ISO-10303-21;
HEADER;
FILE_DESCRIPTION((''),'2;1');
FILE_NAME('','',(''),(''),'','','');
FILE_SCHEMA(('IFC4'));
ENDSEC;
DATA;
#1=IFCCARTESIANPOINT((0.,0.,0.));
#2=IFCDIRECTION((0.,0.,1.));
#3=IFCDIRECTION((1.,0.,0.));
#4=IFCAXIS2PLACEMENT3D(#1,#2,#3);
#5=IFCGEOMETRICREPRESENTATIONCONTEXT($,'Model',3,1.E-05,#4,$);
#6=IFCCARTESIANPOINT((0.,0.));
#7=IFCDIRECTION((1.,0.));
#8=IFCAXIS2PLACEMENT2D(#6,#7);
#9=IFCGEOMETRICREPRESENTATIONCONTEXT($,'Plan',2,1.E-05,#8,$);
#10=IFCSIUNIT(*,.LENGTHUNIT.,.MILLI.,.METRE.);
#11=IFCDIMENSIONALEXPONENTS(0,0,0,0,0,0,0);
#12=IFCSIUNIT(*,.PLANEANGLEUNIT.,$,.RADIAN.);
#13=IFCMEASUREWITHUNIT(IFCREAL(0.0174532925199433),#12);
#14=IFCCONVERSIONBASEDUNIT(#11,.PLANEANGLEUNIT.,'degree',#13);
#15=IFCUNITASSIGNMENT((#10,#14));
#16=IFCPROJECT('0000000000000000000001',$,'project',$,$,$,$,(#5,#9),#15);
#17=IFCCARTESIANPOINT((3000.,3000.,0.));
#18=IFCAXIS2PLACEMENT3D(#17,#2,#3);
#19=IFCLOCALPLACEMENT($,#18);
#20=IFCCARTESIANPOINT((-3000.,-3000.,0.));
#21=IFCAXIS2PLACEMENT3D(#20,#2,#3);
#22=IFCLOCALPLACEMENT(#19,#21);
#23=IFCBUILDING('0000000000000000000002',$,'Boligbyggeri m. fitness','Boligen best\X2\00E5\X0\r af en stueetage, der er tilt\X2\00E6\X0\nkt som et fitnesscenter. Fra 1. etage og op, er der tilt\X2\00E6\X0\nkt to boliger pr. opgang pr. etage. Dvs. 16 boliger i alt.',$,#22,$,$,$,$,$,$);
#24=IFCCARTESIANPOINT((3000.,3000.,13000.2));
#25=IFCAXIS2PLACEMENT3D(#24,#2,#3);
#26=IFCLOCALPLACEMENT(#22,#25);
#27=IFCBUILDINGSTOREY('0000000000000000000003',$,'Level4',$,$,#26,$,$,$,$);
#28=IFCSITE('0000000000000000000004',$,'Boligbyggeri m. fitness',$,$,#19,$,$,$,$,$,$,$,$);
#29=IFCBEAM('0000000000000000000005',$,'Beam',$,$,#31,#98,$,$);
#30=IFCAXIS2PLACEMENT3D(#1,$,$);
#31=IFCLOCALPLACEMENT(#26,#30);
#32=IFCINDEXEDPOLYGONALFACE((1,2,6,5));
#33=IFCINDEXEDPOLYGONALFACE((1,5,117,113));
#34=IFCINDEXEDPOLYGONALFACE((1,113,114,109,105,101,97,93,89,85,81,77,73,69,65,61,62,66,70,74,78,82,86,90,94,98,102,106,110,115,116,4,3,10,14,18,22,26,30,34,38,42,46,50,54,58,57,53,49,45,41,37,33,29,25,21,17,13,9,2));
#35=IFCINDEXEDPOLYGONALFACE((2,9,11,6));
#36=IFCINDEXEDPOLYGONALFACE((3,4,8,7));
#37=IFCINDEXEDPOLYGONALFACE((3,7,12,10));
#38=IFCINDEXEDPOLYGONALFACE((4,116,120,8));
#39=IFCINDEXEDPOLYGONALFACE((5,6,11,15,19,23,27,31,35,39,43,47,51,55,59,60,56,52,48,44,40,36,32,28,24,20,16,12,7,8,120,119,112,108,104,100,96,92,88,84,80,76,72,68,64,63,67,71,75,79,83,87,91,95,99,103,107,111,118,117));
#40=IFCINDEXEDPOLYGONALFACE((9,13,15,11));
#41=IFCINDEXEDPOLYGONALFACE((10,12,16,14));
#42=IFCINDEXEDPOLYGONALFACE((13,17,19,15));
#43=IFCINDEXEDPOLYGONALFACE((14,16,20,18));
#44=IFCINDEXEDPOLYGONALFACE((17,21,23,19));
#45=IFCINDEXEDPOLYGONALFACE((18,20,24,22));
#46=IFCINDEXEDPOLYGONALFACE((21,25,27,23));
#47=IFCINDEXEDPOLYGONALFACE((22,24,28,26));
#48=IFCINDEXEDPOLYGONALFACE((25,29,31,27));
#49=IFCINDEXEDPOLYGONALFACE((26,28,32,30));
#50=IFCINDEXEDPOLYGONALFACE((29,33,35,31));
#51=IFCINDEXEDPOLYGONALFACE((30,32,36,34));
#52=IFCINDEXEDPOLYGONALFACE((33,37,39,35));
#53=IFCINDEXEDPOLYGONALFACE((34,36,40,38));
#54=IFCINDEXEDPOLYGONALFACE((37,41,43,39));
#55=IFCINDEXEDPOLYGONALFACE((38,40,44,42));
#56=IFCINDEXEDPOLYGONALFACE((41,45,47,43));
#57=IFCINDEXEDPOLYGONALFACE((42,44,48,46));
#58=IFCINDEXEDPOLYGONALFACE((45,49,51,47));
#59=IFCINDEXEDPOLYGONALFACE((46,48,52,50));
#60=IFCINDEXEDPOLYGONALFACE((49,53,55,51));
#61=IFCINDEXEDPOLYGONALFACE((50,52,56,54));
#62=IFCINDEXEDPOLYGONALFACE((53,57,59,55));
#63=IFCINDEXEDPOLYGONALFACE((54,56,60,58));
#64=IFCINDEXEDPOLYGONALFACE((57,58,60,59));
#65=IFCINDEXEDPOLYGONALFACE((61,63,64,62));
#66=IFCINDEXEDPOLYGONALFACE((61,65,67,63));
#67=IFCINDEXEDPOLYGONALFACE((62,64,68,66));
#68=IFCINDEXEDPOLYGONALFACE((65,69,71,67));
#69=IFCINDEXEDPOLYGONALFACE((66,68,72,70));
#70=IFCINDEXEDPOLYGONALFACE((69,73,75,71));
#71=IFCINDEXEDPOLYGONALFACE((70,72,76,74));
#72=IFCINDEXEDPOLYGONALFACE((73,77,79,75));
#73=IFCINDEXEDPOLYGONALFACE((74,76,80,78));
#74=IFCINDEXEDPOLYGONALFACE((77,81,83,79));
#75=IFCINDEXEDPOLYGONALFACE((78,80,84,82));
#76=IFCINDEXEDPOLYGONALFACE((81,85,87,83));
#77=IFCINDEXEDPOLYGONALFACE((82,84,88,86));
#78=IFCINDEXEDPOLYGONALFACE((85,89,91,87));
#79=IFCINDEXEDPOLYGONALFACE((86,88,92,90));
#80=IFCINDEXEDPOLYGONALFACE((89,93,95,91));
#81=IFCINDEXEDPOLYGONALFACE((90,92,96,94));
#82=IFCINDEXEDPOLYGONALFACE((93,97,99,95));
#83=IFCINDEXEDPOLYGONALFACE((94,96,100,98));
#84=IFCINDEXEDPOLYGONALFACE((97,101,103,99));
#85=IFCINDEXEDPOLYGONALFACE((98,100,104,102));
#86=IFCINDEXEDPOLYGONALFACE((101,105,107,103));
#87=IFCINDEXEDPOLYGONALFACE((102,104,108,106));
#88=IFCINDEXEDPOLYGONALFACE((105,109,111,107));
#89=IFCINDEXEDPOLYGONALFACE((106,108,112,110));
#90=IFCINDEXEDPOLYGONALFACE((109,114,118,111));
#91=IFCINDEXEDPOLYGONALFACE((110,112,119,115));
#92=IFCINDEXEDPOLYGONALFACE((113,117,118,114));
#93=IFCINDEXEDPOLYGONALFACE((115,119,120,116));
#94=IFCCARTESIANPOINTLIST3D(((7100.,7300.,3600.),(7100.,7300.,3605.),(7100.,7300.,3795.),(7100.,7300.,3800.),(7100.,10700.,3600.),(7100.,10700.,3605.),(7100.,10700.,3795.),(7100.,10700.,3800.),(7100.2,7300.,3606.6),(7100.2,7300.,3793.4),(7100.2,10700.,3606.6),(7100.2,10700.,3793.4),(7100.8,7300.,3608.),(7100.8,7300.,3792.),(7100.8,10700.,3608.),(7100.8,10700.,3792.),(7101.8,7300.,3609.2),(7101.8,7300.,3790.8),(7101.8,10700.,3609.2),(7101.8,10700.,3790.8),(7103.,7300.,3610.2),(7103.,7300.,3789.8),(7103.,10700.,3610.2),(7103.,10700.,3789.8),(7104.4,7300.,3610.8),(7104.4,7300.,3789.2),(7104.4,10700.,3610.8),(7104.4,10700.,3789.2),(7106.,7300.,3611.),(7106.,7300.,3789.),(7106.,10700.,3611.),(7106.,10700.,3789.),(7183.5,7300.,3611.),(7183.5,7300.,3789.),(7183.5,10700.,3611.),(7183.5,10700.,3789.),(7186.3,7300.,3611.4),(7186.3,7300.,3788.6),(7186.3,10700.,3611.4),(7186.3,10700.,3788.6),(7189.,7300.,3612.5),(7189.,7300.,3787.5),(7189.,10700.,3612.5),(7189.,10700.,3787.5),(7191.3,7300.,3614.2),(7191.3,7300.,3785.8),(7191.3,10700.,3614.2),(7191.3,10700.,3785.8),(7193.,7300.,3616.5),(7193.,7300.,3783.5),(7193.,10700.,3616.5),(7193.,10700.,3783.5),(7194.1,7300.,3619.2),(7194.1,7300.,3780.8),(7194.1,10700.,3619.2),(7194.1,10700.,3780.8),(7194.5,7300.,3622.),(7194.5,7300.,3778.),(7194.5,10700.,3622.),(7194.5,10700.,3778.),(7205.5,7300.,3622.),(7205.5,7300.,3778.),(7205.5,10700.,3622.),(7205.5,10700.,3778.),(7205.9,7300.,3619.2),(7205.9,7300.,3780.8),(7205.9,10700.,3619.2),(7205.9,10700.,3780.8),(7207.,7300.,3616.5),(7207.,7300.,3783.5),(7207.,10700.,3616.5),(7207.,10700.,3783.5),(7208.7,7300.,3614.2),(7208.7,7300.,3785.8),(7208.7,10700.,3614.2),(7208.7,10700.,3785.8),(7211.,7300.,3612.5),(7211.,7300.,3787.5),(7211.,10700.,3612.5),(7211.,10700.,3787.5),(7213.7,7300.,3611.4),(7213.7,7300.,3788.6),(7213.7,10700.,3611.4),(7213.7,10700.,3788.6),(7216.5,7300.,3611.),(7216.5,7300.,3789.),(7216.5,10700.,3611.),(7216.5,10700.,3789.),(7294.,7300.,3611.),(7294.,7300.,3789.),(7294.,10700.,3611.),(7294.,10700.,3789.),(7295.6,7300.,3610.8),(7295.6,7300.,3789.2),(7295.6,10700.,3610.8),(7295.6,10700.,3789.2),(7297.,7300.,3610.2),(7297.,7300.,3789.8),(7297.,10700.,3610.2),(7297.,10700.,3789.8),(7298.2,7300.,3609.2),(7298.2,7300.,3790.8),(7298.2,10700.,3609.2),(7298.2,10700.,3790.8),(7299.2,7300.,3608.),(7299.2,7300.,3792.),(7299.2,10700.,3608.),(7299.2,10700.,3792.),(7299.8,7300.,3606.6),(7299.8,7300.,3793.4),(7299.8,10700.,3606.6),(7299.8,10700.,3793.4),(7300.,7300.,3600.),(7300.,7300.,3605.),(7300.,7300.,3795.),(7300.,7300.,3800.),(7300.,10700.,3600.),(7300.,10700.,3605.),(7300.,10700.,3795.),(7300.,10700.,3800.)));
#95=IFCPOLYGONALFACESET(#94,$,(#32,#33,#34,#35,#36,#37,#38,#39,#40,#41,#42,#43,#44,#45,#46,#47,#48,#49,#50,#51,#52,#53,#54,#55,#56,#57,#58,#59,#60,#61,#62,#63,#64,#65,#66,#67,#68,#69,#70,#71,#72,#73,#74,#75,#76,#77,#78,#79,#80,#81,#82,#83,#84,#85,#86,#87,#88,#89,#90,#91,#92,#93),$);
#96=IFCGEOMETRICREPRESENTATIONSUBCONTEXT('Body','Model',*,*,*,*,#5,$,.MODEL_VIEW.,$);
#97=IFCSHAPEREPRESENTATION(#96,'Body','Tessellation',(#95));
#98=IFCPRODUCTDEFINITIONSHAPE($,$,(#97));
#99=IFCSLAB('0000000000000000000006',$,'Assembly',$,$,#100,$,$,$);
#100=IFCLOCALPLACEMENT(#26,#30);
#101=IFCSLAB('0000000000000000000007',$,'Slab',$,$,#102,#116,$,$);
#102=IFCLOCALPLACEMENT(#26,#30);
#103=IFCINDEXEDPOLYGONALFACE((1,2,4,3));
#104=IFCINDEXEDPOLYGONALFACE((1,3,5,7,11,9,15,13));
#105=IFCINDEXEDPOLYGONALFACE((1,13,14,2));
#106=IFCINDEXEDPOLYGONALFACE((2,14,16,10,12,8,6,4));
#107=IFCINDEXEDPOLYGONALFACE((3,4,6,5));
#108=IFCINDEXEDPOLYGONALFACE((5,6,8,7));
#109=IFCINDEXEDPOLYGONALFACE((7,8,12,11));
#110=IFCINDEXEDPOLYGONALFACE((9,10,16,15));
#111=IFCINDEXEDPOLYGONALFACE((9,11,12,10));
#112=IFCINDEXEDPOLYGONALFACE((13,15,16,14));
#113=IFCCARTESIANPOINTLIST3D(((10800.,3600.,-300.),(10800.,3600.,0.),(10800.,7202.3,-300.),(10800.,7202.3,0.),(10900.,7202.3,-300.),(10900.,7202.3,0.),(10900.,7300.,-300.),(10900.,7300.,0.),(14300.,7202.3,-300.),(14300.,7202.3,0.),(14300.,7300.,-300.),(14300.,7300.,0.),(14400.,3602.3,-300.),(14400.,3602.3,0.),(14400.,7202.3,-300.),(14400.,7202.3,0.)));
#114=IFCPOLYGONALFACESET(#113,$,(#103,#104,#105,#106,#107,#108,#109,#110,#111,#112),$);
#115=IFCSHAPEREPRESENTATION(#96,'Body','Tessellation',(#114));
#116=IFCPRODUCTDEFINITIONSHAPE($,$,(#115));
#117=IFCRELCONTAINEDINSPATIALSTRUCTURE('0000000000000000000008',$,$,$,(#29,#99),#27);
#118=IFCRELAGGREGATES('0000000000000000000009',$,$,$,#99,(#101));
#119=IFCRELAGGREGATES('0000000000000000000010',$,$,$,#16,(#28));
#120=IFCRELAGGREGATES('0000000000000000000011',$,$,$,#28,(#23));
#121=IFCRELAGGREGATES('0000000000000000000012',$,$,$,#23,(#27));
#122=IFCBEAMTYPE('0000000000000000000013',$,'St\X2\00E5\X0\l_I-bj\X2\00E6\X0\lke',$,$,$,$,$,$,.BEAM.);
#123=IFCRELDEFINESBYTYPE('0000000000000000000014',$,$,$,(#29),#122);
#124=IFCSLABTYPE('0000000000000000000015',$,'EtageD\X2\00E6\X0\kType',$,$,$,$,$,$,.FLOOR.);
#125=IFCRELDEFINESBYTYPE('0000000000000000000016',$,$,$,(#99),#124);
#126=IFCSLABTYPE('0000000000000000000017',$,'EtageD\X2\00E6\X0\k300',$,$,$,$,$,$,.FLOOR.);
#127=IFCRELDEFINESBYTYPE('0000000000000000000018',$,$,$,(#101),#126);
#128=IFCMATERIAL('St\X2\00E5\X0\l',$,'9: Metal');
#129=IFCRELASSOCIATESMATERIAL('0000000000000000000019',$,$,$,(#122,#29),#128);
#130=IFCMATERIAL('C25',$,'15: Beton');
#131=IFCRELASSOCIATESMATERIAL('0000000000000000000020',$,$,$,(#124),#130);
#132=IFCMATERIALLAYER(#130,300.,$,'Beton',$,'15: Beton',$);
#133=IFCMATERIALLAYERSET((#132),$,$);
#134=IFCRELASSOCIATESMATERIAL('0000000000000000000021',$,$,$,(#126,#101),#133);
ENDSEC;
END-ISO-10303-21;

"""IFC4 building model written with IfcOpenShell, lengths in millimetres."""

from ifc_helpers import new_model, entity, si_unit, converted_unit, frame, origin_with_axes, origin_2d_with_axis, place, context, subcontext, project, spatial, line, indexed_curve, i_section, outline, extrude, material, layer, layer_set, layer_usage, material_profile, profile_set, profile_usage, type_object, element, aggregate, save


model = new_model("IFC4")

# Units and contexts
model_context = context("Model", 3, precision=1e-05, world=origin_with_axes())
plan_context = context("Plan", 2, precision=1e-05, world=origin_2d_with_axis())
body_context = subcontext(model_context, "Body", "Model", "MODEL_VIEW")
ifc_project = project(units=[si_unit("LENGTHUNIT", "METRE", prefix="MILLI"), converted_unit("PLANEANGLEUNIT", "degree", entity("IfcReal", 0.0174532925199433), si_unit("PLANEANGLEUNIT", "RADIAN"), dimensions=[0, 0, 0, 0, 0, 0, 0])], contexts=[model_context, plan_context])

# Site, building, storey
site_placement = place(None, frame((3000.0, 3000.0, 0.0), z_axis=(0.0, 0.0, 1.0), x_axis=(1.0, 0.0, 0.0)))
site = spatial("IfcSite", under=ifc_project, at=site_placement, Name="Boligbyggeri m. fitness")
building_placement = place(site_placement, frame((-3000.0, -3000.0, 0.0), z_axis=(0.0, 0.0, 1.0), x_axis=(1.0, 0.0, 0.0)))
building = spatial("IfcBuilding", under=site, at=building_placement, Name="Boligbyggeri m. fitness", Description="Boligen består af en stueetage, der er tiltænkt som et fitnesscenter. Fra 1. etage og op, er der tiltænkt to boliger pr. opgang pr. etage. Dvs. 16 boliger i alt.")
storey_placement = place(building_placement, frame((3000.0, 3000.0, 13000.2), z_axis=(0.0, 0.0, 1.0), x_axis=(1.0, 0.0, 0.0)))
storey = spatial("IfcBuildingStorey", under=building, at=storey_placement, Name="Level4")

# Shared definitions
ifc_material_1 = material(Name="C25", Category="15: Beton")

# Beam
ifc_material_2 = material(Name="Stål", Category="9: Metal")
ifc_material_profile_1 = material_profile(ifc_material_2, i_section(OverallWidth=200.0, OverallDepth=200.0, WebThickness=11.0, FlangeThickness=11.0, FilletRadius=11.0, FlangeEdgeRadius=6.0), Name="Stål", Category="9: Metal")
ifc_profile_set_1 = profile_set([ifc_material_profile_1], Name="NY_I-Profil")
beam_type = type_object("IfcBeamType", Name="Stål_I-bjælke", PredefinedType="BEAM", material=ifc_profile_set_1)
ifc_profile_usage_1 = profile_usage(ifc_profile_set_1, cardinal=9)
beam_1_placement = place(storey_placement, frame((7300.0, 7300.0, 3800.0), z_axis=(0.0, 1.0, 0.0), x_axis=(-1.0, 0.0, 0.0)))
element("IfcBeam", 1, at=beam_1_placement, inside=storey, type_object=beam_type, material=ifc_profile_usage_1, Name="Beam", context=body_context, shape_type="SweptSolid", body=[
    extrude(i_section(OverallWidth=200.0, OverallDepth=200.0, WebThickness=11.0, FlangeThickness=11.0, FilletRadius=11.0, FlangeEdgeRadius=6.0), frame((100.0, -100.0, 0.0), z_axis=(0.0, 0.0, 1.0), x_axis=(1.0, 0.0, 0.0)), (0.0, 0.0, 1.0), 3400.0),
])

# Slabs
slab_type_1 = type_object("IfcSlabType", Name="EtageDækType", PredefinedType="FLOOR", material=ifc_material_1)
slab_1_placement = place(storey_placement, frame((25300.0, 3700.0, -12999.9), z_axis=(0.0, 0.0, 1.0), x_axis=(1.0, 0.0, 0.0)))
slab_1 = element("IfcSlab", 2, at=slab_1_placement, inside=storey, type_object=slab_type_1, Name="Assembly")
ifc_layer = layer(ifc_material_1, 300.0, Name="Beton", Category="15: Beton")
ifc_layer_set = layer_set([ifc_layer])
slab_type_2 = type_object("IfcSlabType", Name="EtageDæk300", PredefinedType="FLOOR", material=ifc_layer_set)
ifc_layer_usage_1 = layer_usage(ifc_layer_set, "AXIS3", "POSITIVE", 0.0)
slab_2_placement = place(slab_1_placement, frame((-14500.0, -97.7, 12699.9), z_axis=(0.0, 0.0, 1.0), x_axis=(1.0, 0.0, 0.0)))
slab_2 = element("IfcSlab", 3, at=slab_2_placement, type_object=slab_type_2, material=ifc_layer_usage_1, Name="Slab", context=body_context, shape_type="SweptSolid", body=[
    extrude(outline(indexed_curve([(100.0, 3697.7), (3500.0, 3697.7), (3500.0, 3600.0), (3600.0, 3600.0), (3600.0, 0.0), (0.0, -2.3), (0.0, 3600.0), (100.0, 3600.0)], segments=[line(5, 6), line(6, 7), line(7, 8), line(8, 1), line(1, 2), line(2, 3), line(3, 4), line(4, 5)], self_intersect=False)), None, (0.0, 0.0, 1.0), 300.0),
])
aggregate(slab_1, [slab_2])

save(model, "model.ifc")
